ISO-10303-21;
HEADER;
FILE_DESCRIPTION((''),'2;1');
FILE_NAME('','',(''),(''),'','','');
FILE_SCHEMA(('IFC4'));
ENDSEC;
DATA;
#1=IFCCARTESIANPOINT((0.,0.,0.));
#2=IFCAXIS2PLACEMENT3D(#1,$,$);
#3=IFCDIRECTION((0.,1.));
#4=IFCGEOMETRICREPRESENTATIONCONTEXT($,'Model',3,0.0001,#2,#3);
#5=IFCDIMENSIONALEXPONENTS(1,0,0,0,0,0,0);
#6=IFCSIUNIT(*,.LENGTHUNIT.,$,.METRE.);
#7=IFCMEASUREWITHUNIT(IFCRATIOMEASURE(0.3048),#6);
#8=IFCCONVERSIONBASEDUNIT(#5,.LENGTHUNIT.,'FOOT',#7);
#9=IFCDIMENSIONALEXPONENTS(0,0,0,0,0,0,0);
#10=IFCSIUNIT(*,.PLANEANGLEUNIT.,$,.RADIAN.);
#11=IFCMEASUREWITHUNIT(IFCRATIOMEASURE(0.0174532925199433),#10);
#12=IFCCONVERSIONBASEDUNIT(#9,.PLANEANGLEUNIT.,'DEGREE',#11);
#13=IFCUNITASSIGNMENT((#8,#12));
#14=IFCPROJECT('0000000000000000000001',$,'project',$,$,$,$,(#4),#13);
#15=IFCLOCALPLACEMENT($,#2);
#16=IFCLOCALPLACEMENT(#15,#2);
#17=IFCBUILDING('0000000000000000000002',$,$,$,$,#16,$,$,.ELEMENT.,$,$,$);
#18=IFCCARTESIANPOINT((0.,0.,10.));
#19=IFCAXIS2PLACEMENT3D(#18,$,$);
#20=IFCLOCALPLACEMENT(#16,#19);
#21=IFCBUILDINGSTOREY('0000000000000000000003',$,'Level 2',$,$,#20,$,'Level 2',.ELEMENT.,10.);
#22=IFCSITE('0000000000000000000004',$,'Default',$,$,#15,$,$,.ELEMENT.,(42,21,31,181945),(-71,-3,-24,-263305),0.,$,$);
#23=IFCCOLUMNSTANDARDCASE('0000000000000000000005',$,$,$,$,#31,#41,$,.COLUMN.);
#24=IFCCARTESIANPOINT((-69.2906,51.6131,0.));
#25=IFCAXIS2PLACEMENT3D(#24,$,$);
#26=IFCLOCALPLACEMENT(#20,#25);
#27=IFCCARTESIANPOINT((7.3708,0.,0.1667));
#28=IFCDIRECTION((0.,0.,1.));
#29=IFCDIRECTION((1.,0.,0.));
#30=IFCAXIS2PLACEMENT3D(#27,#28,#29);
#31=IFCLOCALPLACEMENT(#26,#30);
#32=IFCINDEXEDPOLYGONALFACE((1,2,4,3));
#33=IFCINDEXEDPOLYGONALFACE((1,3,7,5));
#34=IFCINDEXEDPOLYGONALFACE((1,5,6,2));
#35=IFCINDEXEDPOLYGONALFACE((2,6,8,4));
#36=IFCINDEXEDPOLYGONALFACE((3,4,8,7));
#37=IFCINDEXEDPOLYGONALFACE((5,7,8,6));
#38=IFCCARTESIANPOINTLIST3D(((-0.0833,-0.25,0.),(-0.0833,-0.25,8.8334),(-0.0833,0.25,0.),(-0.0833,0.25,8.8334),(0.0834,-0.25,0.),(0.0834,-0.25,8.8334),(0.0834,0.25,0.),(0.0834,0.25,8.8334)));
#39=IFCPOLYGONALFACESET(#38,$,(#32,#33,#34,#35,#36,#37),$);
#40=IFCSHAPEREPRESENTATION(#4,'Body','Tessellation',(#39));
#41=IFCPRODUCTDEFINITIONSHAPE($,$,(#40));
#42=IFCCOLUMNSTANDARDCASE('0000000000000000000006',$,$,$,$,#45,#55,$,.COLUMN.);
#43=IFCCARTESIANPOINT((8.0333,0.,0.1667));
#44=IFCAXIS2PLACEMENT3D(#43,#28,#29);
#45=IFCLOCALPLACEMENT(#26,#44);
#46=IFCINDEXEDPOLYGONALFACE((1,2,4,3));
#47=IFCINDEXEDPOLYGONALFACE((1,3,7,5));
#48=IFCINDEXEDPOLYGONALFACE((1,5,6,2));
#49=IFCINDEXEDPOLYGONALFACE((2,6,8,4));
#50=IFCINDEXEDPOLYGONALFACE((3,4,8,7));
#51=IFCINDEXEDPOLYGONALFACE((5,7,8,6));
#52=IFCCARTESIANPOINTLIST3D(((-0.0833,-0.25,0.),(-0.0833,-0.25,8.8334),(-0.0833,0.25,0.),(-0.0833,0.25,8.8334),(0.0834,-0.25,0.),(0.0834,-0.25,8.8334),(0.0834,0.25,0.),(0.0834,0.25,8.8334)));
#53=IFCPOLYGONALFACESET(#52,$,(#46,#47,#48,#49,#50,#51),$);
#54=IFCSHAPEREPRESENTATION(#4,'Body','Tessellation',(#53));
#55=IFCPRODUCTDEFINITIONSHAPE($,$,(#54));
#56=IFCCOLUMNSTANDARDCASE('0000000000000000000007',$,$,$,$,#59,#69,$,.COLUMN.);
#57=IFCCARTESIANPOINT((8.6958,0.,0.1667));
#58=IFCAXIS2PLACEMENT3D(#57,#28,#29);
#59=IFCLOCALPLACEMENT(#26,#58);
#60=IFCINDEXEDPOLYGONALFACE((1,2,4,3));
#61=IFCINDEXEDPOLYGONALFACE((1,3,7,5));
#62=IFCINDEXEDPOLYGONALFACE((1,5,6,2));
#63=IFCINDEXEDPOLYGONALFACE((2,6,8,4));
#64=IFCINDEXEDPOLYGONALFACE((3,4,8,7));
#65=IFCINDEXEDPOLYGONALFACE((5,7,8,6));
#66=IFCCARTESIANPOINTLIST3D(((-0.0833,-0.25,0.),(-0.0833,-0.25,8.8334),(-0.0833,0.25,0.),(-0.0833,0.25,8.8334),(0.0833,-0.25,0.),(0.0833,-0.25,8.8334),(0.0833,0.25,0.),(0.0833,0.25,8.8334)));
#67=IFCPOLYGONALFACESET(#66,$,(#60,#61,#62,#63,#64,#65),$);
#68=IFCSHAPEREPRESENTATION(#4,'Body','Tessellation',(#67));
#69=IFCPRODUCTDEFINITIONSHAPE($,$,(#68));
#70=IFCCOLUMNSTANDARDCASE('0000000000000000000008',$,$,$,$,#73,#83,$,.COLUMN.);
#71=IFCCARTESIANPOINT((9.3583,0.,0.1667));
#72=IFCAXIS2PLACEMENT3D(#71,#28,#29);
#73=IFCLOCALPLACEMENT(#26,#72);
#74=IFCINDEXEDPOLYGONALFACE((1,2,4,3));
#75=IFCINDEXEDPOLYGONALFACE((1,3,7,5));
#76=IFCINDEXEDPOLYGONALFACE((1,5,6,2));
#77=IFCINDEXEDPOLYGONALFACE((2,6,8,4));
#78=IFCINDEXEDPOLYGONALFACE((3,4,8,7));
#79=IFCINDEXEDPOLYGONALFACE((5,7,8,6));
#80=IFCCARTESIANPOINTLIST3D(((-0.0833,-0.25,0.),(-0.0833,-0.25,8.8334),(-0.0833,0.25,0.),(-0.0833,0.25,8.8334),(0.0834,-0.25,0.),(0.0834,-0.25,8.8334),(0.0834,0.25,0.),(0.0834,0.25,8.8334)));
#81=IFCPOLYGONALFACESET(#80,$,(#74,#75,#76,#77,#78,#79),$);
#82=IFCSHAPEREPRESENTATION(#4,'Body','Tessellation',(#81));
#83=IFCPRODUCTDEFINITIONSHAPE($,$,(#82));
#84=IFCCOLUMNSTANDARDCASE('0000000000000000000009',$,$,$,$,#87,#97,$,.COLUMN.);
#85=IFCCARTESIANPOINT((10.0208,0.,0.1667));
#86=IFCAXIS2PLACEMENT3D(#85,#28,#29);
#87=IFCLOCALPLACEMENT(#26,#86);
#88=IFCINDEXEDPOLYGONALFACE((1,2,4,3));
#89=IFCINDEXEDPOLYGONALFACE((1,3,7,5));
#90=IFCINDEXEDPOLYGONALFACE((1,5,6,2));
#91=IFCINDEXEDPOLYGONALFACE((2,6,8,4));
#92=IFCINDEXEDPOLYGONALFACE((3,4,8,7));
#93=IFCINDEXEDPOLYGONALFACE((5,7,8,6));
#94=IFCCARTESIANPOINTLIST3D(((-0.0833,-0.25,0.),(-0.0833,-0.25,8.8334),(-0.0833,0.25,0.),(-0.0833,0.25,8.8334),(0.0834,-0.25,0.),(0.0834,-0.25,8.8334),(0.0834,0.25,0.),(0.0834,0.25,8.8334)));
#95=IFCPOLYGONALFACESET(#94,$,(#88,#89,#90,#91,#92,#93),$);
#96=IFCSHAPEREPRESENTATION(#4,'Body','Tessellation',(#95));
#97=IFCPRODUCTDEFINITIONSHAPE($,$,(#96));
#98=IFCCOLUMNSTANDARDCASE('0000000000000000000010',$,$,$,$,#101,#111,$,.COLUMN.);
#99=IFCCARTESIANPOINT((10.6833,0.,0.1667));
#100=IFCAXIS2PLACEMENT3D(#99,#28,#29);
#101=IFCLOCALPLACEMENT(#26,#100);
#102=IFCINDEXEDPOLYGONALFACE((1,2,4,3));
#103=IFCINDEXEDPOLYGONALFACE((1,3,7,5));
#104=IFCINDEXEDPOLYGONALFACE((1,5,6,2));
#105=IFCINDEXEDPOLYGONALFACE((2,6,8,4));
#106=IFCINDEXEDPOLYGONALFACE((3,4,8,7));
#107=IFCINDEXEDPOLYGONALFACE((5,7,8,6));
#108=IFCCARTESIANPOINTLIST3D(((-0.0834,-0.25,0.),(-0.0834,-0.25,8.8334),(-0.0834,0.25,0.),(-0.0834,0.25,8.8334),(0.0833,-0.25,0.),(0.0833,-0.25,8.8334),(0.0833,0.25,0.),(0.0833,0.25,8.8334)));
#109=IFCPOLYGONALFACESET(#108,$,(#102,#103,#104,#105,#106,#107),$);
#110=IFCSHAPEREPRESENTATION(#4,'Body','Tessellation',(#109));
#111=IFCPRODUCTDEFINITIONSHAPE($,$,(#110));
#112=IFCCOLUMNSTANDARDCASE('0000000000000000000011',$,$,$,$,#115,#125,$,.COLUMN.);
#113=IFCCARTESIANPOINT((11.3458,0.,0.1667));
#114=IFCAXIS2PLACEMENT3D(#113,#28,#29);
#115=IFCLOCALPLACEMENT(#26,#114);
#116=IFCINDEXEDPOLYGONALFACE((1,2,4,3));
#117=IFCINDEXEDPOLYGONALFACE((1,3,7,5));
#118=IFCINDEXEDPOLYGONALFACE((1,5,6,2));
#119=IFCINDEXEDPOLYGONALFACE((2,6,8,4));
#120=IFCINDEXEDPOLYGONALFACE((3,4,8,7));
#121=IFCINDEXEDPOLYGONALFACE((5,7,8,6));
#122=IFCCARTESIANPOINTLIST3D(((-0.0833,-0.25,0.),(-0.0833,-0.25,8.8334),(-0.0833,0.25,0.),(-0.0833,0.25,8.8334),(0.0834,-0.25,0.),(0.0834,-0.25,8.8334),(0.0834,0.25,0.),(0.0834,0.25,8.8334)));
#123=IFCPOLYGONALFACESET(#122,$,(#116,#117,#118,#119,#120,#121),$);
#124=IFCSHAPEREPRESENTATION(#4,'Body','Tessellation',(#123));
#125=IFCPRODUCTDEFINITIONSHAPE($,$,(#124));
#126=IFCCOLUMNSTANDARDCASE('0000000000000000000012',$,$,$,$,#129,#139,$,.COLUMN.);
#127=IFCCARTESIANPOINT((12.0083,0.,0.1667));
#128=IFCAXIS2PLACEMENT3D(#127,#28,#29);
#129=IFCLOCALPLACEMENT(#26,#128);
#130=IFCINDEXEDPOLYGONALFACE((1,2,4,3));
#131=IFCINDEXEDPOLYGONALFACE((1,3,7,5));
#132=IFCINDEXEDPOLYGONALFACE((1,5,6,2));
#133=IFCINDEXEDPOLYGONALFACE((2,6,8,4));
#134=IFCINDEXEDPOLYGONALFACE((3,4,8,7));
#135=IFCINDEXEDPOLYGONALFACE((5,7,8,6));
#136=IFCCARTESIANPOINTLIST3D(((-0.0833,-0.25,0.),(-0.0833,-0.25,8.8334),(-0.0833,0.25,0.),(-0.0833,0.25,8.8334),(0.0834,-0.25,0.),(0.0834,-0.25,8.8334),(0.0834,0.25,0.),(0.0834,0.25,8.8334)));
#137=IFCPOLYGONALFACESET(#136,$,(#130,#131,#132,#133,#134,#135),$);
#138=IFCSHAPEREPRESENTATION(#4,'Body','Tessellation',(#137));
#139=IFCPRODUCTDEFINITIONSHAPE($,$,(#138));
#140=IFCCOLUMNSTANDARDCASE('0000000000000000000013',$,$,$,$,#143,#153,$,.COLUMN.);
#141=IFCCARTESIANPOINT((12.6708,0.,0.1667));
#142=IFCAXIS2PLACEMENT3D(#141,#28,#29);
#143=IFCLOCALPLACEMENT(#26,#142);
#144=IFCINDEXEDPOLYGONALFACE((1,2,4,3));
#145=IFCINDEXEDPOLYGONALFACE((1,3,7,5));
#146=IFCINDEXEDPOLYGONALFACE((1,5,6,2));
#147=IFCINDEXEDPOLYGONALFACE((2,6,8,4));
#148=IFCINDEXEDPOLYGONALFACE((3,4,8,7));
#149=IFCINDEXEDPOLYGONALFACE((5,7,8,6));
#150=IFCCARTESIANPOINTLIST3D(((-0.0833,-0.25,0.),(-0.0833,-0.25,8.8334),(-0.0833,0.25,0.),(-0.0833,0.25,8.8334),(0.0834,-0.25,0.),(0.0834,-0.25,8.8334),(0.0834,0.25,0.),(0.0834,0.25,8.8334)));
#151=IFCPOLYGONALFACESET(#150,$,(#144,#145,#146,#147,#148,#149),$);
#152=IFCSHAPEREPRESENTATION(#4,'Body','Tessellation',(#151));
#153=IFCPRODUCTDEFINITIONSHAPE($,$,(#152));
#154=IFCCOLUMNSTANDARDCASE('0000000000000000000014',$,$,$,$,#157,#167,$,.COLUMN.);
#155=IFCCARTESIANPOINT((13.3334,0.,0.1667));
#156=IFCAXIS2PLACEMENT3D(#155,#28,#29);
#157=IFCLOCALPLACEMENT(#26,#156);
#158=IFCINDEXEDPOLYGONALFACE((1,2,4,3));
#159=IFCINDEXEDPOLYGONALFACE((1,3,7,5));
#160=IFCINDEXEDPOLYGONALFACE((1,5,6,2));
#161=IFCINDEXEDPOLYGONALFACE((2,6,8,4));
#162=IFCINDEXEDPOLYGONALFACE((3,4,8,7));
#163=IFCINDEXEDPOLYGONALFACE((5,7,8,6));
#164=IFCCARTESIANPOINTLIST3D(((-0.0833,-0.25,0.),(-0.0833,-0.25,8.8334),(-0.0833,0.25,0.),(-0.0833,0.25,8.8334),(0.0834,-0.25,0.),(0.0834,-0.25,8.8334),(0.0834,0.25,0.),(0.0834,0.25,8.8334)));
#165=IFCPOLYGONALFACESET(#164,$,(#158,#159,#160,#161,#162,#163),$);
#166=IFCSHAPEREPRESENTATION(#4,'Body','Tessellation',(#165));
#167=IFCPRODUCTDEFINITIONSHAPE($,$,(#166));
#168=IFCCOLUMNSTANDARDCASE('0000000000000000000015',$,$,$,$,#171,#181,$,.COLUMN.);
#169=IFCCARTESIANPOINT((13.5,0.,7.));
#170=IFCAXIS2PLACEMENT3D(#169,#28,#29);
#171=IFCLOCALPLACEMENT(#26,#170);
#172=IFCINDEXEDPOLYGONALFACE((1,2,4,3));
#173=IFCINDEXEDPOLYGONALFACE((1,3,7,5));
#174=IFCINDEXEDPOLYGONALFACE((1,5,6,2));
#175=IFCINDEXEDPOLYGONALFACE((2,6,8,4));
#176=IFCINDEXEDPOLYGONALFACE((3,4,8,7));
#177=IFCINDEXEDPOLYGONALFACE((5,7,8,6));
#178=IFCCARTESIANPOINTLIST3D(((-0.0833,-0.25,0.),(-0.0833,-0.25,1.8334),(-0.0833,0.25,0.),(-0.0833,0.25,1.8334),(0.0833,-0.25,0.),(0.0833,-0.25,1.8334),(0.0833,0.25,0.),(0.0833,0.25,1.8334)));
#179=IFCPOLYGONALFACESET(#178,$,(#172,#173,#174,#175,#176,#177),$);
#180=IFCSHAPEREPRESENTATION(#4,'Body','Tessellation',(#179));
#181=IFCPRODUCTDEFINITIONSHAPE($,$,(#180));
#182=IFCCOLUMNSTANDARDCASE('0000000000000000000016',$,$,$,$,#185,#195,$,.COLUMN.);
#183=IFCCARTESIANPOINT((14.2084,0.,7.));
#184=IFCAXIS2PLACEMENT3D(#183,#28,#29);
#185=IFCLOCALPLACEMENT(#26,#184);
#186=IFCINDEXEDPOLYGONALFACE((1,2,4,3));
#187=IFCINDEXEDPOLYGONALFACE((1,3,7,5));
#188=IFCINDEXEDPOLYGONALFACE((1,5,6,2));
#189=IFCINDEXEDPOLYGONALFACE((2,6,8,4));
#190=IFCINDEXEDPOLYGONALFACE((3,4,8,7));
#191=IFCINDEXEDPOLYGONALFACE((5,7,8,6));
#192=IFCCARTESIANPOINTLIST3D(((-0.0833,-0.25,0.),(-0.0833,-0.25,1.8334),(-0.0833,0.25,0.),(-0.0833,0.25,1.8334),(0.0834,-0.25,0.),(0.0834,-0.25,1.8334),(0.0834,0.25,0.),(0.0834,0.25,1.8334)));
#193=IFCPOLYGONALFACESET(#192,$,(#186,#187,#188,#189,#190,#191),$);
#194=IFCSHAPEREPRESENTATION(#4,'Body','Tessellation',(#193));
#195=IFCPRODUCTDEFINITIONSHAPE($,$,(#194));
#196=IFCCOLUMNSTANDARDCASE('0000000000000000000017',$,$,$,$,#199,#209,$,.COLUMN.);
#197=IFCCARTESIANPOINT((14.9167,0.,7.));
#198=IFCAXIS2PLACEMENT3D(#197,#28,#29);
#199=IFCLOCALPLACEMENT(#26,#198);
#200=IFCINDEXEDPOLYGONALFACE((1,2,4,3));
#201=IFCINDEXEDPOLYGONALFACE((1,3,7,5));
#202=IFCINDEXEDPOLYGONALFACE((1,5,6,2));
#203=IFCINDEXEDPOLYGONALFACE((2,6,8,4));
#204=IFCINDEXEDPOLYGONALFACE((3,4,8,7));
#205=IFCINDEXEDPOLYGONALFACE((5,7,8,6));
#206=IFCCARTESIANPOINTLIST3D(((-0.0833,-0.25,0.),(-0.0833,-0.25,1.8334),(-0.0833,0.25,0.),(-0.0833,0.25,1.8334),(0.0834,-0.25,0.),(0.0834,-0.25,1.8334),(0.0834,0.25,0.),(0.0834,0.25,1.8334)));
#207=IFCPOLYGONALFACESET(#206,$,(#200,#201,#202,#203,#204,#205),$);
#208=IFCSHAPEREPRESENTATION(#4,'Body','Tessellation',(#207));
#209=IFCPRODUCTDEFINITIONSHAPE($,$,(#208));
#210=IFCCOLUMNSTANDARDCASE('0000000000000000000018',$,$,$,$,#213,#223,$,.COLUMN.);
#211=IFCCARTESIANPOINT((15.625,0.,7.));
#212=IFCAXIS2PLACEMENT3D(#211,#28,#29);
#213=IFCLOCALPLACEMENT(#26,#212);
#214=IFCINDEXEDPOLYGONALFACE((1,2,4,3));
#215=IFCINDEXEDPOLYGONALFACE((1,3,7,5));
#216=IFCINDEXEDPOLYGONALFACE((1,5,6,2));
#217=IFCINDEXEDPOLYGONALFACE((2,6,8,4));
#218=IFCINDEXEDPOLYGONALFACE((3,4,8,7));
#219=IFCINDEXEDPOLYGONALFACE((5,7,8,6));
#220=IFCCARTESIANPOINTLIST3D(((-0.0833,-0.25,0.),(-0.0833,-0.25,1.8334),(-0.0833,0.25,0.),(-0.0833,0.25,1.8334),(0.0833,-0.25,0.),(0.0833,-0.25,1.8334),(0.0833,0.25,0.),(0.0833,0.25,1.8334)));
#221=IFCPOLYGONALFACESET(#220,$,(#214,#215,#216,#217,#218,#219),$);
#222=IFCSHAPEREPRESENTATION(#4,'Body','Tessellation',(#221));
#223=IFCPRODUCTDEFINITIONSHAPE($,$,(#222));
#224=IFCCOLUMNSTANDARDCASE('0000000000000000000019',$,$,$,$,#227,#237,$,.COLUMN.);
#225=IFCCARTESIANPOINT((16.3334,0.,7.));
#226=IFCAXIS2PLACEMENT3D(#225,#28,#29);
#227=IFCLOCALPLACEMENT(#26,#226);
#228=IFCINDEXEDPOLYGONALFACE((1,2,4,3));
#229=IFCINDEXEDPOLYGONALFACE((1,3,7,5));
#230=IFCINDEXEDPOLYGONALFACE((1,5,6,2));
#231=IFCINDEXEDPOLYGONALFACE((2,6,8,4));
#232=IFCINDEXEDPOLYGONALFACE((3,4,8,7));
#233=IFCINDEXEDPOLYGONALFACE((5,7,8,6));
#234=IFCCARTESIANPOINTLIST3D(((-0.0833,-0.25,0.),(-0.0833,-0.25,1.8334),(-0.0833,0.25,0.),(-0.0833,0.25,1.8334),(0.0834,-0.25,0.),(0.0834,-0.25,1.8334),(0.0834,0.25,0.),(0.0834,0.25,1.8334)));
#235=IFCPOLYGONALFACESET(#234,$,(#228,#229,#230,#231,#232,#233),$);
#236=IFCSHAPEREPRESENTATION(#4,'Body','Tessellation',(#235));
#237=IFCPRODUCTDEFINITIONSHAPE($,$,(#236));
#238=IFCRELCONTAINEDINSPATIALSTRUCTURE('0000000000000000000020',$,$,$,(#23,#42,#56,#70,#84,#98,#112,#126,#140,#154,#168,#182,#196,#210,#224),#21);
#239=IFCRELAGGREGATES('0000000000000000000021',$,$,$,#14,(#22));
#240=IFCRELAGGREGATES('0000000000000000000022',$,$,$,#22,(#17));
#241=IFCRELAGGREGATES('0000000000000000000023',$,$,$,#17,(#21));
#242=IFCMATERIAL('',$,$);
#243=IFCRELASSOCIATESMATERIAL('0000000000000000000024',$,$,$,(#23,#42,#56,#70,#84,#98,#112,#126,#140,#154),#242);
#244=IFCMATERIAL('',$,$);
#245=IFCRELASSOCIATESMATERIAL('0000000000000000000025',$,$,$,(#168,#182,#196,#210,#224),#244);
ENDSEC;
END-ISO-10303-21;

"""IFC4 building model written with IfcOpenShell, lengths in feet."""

from ifc_helpers import new_model, entity, si_unit, converted_unit, direction, frame, origin, place, context, project, spatial, rectangle, extrude, material, element, save


model = new_model("IFC4")

# Units and contexts
model_context = context("Model", 3, precision=0.0001, world=origin(), true_north=direction((0.0, 1.0)))
ifc_project = project(units=[converted_unit("LENGTHUNIT", "FOOT", entity("IfcRatioMeasure", 0.3048), si_unit("LENGTHUNIT", "METRE"), dimensions=[1, 0, 0, 0, 0, 0, 0]), converted_unit("PLANEANGLEUNIT", "DEGREE", entity("IfcRatioMeasure", 0.0174532925199433), si_unit("PLANEANGLEUNIT", "RADIAN"), dimensions=[0, 0, 0, 0, 0, 0, 0])], contexts=[model_context])

# Site, building, storey
site_placement = place(None, origin())
site = spatial("IfcSite", under=ifc_project, at=site_placement, Name="Default", CompositionType="ELEMENT", RefLatitude=(42, 21, 31, 181945), RefLongitude=(-71, -3, -24, -263305), RefElevation=0.0)
building_placement = place(site_placement, origin())
building = spatial("IfcBuilding", under=site, at=building_placement, CompositionType="ELEMENT")
storey_placement = place(building_placement, frame((0.0, 0.0, 10.0)))
storey = spatial("IfcBuildingStorey", under=building, at=storey_placement, Name="Level 2", LongName="Level 2", CompositionType="ELEMENT", Elevation=10.0)

# Columns
ifc_material_1 = material(Name="")
placement_1 = place(storey_placement, frame((-69.2906, 51.6131, 0.0)))
for number, where, z_axis, x_axis in (
    (1, (7.3708, 0.0, 0.1667), (0.0, 0.0, 1.0), (1.0, 0.0, 0.0)),
    (2, (8.0333, 0.0, 0.1667), (0.0, 0.0, 1.0), (1.0, 0.0, 0.0)),
    (3, (8.6958, 0.0, 0.1667), (0.0, 0.0, 1.0), (1.0, 0.0, 0.0)),
    (4, (9.3583, 0.0, 0.1667), (0.0, 0.0, 1.0), (1.0, 0.0, 0.0)),
    (5, (10.0208, 0.0, 0.1667), (0.0, 0.0, 1.0), (1.0, 0.0, 0.0)),
    (6, (10.6833, 0.0, 0.1667), (0.0, 0.0, 1.0), (1.0, 0.0, 0.0)),
    (7, (11.3458, 0.0, 0.1667), (0.0, 0.0, 1.0), (1.0, 0.0, 0.0)),
    (8, (12.0083, 0.0, 0.1667), (0.0, 0.0, 1.0), (1.0, 0.0, 0.0)),
    (9, (12.6708, 0.0, 0.1667), (0.0, 0.0, 1.0), (1.0, 0.0, 0.0)),
    (10, (13.3334, 0.0, 0.1667), (0.0, 0.0, 1.0), (1.0, 0.0, 0.0)),
):
    element("IfcColumnStandardCase", number, at=place(placement_1, frame(where, z_axis=z_axis, x_axis=x_axis)), inside=storey, material=ifc_material_1, PredefinedType="COLUMN", context=model_context, shape_type="SweptSolid", body=[
        extrude(rectangle(XDim=0.1667, YDim=0.5), origin(), (0.0, 0.0, 1.0), 8.8334),
    ])
ifc_material_2 = material(Name="")
for number, where, z_axis, x_axis in (
    (11, (13.5, 0.0, 7.0), (0.0, 0.0, 1.0), (1.0, 0.0, 0.0)),
    (12, (14.2084, 0.0, 7.0), (0.0, 0.0, 1.0), (1.0, 0.0, 0.0)),
    (13, (14.9167, 0.0, 7.0), (0.0, 0.0, 1.0), (1.0, 0.0, 0.0)),
    (14, (15.625, 0.0, 7.0), (0.0, 0.0, 1.0), (1.0, 0.0, 0.0)),
    (15, (16.3334, 0.0, 7.0), (0.0, 0.0, 1.0), (1.0, 0.0, 0.0)),
):
    element("IfcColumnStandardCase", number, at=place(placement_1, frame(where, z_axis=z_axis, x_axis=x_axis)), inside=storey, material=ifc_material_2, PredefinedType="COLUMN", context=model_context, shape_type="SweptSolid", body=[
        extrude(rectangle(XDim=0.1667, YDim=0.5), origin(), (0.0, 0.0, 1.0), 1.8334),
    ])

save(model, "model.ifc")
